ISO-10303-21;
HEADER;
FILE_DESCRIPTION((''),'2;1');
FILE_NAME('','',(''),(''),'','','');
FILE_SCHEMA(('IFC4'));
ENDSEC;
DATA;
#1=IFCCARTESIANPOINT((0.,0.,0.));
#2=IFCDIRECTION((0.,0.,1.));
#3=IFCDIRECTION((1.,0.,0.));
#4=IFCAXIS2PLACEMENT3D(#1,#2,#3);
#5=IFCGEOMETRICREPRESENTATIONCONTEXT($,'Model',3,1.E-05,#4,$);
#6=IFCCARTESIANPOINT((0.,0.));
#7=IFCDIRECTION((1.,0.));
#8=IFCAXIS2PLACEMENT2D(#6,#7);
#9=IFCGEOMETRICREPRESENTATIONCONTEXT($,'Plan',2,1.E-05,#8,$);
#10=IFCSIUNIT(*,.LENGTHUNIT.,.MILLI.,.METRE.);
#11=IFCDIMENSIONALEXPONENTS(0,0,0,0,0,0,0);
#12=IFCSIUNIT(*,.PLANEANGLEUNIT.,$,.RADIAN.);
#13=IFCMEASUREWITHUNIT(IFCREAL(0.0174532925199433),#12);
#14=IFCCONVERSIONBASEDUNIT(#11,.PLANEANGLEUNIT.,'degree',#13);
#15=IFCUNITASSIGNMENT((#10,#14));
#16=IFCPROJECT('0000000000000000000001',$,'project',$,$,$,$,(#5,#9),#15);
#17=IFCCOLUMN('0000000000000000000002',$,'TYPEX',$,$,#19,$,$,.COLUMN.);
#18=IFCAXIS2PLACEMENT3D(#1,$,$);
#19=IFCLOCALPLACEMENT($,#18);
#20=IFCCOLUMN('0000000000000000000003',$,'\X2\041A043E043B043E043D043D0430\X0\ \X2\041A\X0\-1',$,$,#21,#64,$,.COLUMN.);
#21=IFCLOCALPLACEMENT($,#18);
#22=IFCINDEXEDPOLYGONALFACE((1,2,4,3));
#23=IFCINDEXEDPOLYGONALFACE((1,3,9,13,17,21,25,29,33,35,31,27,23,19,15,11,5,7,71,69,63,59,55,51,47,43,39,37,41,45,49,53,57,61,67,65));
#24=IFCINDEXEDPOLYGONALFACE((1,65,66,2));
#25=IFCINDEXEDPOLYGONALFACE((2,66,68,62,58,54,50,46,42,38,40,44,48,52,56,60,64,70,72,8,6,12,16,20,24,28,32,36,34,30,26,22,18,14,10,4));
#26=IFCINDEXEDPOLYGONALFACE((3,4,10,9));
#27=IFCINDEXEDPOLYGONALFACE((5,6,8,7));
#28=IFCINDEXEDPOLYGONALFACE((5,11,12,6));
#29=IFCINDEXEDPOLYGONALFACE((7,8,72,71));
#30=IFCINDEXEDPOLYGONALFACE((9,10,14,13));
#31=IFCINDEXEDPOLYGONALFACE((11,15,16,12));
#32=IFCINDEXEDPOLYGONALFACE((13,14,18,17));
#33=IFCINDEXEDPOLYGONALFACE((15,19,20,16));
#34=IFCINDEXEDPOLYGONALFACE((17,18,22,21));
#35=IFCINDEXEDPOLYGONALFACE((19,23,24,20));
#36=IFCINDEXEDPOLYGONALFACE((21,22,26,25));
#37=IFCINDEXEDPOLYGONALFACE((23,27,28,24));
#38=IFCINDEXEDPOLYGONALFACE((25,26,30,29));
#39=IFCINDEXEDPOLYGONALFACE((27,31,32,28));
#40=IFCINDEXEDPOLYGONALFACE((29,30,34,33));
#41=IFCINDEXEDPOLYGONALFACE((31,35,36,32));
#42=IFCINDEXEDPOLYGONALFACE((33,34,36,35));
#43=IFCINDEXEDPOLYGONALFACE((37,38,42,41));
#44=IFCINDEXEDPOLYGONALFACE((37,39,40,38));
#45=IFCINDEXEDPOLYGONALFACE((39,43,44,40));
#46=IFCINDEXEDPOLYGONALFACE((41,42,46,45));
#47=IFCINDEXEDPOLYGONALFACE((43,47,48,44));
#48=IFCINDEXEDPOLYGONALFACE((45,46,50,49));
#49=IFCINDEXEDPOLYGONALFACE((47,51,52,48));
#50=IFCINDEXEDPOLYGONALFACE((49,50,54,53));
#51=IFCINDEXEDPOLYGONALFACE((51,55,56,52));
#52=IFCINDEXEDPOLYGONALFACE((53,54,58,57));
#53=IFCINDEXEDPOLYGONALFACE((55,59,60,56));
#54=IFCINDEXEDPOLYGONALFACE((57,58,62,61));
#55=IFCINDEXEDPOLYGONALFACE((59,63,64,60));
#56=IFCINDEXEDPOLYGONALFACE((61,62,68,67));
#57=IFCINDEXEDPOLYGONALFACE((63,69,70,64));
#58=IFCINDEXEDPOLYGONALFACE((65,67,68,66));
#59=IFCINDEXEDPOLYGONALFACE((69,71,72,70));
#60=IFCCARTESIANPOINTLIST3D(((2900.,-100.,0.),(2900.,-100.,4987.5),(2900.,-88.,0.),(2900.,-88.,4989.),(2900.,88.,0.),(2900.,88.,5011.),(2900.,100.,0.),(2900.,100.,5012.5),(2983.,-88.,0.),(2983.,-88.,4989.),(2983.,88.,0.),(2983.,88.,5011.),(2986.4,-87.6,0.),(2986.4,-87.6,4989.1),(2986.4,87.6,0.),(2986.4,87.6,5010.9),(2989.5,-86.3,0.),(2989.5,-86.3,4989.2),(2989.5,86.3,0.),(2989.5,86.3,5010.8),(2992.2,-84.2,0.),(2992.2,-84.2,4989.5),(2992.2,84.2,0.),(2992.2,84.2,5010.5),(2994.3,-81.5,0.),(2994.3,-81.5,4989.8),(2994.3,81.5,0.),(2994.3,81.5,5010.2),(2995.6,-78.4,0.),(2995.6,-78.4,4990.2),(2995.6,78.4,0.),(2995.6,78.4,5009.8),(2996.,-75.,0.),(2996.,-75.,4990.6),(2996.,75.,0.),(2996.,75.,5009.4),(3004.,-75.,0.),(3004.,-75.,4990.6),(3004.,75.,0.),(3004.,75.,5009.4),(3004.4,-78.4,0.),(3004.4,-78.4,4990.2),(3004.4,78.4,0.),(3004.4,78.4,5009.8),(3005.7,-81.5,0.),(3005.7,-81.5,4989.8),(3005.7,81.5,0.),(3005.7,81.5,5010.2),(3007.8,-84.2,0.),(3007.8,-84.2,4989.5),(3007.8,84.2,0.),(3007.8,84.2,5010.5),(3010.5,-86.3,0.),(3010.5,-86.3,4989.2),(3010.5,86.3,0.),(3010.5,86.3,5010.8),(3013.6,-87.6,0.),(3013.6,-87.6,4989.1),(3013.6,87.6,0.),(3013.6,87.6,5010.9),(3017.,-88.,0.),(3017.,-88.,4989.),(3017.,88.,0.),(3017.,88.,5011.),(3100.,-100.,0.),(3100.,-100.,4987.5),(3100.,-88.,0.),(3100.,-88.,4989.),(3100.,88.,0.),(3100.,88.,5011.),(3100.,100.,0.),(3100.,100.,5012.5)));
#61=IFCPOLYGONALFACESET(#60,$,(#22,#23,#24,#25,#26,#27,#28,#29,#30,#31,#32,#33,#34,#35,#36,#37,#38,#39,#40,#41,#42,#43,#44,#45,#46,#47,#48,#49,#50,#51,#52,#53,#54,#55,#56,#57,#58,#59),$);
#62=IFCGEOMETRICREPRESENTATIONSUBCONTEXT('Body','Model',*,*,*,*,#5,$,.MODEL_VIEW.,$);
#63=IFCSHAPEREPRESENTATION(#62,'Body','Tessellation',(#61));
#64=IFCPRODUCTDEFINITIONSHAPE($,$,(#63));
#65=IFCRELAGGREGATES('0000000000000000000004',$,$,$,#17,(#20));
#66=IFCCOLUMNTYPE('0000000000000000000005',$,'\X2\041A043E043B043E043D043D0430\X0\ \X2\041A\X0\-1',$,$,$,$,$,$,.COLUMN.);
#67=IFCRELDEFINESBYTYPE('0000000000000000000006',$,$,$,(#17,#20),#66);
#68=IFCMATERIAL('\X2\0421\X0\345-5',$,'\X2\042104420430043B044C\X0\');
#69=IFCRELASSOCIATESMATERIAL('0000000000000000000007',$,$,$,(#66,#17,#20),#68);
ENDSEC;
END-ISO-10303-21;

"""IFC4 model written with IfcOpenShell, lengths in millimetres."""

from ifc_helpers import new_model, entity, si_unit, converted_unit, frame, origin_with_axes, origin_2d_with_axis, place, context, subcontext, project, i_section, extrude, clip, halfspace, material, material_profile, profile_set, profile_usage, type_object, element, aggregate, save


model = new_model("IFC4")

# Units and contexts
model_context = context("Model", 3, precision=1e-05, world=origin_with_axes())
plan_context = context("Plan", 2, precision=1e-05, world=origin_2d_with_axis())
body_context = subcontext(model_context, "Body", "Model", "MODEL_VIEW")
ifc_project = project(units=[si_unit("LENGTHUNIT", "METRE", prefix="MILLI"), converted_unit("PLANEANGLEUNIT", "degree", entity("IfcReal", 0.0174532925199433), si_unit("PLANEANGLEUNIT", "RADIAN"), dimensions=[0, 0, 0, 0, 0, 0, 0])], contexts=[model_context, plan_context])

# Columns
ifc_material = material(Name="С345-5", Category="Сталь")
ifc_material_profile = material_profile(ifc_material, i_section(OverallWidth=200.0, OverallDepth=200.0, WebThickness=8.0, FlangeThickness=12.0, FilletRadius=13.0, FlangeEdgeRadius=0.0, FlangeSlope=0.0))
ifc_profile_set = profile_set([ifc_material_profile], Name="I20K2_S345-5")
ifc_profile_usage_1 = profile_usage(ifc_profile_set)
column_type = type_object("IfcColumnType", Name="Колонна К-1", PredefinedType="COLUMN", material=ifc_profile_set)
column_1_placement = place(None, frame((3000.0, 0.0, 0.0), z_axis=(0.0, 0.0, 1.0), x_axis=(1.0, 0.0, 0.0)))
column_1 = element("IfcColumn", 1, at=column_1_placement, type_object=column_type, material=ifc_profile_usage_1, Name="TYPEX", PredefinedType="COLUMN")
ifc_profile_usage_2 = profile_usage(ifc_profile_set, cardinal=5)
column_2_placement = place(column_1_placement, origin_with_axes())
column_2 = element("IfcColumn", 2, at=column_2_placement, type_object=column_type, material=ifc_profile_usage_2, Name="Колонна К-1", PredefinedType="COLUMN", context=body_context, shape_type="Clipping", body=[
    clip(extrude(i_section(OverallWidth=200.0, OverallDepth=200.0, WebThickness=8.0, FlangeThickness=12.0, FilletRadius=13.0, FlangeEdgeRadius=0.0, FlangeSlope=0.0), origin_with_axes(), (0.0, 0.0, 1.0), 5200.0), halfspace(frame((0.0, -298.5, 4962.7), z_axis=(0.0, -0.124035, 0.992278), x_axis=(0.0, 0.992278, 0.124035)), False)),
])
aggregate(column_1, [column_2])

save(model, "model.ifc")
